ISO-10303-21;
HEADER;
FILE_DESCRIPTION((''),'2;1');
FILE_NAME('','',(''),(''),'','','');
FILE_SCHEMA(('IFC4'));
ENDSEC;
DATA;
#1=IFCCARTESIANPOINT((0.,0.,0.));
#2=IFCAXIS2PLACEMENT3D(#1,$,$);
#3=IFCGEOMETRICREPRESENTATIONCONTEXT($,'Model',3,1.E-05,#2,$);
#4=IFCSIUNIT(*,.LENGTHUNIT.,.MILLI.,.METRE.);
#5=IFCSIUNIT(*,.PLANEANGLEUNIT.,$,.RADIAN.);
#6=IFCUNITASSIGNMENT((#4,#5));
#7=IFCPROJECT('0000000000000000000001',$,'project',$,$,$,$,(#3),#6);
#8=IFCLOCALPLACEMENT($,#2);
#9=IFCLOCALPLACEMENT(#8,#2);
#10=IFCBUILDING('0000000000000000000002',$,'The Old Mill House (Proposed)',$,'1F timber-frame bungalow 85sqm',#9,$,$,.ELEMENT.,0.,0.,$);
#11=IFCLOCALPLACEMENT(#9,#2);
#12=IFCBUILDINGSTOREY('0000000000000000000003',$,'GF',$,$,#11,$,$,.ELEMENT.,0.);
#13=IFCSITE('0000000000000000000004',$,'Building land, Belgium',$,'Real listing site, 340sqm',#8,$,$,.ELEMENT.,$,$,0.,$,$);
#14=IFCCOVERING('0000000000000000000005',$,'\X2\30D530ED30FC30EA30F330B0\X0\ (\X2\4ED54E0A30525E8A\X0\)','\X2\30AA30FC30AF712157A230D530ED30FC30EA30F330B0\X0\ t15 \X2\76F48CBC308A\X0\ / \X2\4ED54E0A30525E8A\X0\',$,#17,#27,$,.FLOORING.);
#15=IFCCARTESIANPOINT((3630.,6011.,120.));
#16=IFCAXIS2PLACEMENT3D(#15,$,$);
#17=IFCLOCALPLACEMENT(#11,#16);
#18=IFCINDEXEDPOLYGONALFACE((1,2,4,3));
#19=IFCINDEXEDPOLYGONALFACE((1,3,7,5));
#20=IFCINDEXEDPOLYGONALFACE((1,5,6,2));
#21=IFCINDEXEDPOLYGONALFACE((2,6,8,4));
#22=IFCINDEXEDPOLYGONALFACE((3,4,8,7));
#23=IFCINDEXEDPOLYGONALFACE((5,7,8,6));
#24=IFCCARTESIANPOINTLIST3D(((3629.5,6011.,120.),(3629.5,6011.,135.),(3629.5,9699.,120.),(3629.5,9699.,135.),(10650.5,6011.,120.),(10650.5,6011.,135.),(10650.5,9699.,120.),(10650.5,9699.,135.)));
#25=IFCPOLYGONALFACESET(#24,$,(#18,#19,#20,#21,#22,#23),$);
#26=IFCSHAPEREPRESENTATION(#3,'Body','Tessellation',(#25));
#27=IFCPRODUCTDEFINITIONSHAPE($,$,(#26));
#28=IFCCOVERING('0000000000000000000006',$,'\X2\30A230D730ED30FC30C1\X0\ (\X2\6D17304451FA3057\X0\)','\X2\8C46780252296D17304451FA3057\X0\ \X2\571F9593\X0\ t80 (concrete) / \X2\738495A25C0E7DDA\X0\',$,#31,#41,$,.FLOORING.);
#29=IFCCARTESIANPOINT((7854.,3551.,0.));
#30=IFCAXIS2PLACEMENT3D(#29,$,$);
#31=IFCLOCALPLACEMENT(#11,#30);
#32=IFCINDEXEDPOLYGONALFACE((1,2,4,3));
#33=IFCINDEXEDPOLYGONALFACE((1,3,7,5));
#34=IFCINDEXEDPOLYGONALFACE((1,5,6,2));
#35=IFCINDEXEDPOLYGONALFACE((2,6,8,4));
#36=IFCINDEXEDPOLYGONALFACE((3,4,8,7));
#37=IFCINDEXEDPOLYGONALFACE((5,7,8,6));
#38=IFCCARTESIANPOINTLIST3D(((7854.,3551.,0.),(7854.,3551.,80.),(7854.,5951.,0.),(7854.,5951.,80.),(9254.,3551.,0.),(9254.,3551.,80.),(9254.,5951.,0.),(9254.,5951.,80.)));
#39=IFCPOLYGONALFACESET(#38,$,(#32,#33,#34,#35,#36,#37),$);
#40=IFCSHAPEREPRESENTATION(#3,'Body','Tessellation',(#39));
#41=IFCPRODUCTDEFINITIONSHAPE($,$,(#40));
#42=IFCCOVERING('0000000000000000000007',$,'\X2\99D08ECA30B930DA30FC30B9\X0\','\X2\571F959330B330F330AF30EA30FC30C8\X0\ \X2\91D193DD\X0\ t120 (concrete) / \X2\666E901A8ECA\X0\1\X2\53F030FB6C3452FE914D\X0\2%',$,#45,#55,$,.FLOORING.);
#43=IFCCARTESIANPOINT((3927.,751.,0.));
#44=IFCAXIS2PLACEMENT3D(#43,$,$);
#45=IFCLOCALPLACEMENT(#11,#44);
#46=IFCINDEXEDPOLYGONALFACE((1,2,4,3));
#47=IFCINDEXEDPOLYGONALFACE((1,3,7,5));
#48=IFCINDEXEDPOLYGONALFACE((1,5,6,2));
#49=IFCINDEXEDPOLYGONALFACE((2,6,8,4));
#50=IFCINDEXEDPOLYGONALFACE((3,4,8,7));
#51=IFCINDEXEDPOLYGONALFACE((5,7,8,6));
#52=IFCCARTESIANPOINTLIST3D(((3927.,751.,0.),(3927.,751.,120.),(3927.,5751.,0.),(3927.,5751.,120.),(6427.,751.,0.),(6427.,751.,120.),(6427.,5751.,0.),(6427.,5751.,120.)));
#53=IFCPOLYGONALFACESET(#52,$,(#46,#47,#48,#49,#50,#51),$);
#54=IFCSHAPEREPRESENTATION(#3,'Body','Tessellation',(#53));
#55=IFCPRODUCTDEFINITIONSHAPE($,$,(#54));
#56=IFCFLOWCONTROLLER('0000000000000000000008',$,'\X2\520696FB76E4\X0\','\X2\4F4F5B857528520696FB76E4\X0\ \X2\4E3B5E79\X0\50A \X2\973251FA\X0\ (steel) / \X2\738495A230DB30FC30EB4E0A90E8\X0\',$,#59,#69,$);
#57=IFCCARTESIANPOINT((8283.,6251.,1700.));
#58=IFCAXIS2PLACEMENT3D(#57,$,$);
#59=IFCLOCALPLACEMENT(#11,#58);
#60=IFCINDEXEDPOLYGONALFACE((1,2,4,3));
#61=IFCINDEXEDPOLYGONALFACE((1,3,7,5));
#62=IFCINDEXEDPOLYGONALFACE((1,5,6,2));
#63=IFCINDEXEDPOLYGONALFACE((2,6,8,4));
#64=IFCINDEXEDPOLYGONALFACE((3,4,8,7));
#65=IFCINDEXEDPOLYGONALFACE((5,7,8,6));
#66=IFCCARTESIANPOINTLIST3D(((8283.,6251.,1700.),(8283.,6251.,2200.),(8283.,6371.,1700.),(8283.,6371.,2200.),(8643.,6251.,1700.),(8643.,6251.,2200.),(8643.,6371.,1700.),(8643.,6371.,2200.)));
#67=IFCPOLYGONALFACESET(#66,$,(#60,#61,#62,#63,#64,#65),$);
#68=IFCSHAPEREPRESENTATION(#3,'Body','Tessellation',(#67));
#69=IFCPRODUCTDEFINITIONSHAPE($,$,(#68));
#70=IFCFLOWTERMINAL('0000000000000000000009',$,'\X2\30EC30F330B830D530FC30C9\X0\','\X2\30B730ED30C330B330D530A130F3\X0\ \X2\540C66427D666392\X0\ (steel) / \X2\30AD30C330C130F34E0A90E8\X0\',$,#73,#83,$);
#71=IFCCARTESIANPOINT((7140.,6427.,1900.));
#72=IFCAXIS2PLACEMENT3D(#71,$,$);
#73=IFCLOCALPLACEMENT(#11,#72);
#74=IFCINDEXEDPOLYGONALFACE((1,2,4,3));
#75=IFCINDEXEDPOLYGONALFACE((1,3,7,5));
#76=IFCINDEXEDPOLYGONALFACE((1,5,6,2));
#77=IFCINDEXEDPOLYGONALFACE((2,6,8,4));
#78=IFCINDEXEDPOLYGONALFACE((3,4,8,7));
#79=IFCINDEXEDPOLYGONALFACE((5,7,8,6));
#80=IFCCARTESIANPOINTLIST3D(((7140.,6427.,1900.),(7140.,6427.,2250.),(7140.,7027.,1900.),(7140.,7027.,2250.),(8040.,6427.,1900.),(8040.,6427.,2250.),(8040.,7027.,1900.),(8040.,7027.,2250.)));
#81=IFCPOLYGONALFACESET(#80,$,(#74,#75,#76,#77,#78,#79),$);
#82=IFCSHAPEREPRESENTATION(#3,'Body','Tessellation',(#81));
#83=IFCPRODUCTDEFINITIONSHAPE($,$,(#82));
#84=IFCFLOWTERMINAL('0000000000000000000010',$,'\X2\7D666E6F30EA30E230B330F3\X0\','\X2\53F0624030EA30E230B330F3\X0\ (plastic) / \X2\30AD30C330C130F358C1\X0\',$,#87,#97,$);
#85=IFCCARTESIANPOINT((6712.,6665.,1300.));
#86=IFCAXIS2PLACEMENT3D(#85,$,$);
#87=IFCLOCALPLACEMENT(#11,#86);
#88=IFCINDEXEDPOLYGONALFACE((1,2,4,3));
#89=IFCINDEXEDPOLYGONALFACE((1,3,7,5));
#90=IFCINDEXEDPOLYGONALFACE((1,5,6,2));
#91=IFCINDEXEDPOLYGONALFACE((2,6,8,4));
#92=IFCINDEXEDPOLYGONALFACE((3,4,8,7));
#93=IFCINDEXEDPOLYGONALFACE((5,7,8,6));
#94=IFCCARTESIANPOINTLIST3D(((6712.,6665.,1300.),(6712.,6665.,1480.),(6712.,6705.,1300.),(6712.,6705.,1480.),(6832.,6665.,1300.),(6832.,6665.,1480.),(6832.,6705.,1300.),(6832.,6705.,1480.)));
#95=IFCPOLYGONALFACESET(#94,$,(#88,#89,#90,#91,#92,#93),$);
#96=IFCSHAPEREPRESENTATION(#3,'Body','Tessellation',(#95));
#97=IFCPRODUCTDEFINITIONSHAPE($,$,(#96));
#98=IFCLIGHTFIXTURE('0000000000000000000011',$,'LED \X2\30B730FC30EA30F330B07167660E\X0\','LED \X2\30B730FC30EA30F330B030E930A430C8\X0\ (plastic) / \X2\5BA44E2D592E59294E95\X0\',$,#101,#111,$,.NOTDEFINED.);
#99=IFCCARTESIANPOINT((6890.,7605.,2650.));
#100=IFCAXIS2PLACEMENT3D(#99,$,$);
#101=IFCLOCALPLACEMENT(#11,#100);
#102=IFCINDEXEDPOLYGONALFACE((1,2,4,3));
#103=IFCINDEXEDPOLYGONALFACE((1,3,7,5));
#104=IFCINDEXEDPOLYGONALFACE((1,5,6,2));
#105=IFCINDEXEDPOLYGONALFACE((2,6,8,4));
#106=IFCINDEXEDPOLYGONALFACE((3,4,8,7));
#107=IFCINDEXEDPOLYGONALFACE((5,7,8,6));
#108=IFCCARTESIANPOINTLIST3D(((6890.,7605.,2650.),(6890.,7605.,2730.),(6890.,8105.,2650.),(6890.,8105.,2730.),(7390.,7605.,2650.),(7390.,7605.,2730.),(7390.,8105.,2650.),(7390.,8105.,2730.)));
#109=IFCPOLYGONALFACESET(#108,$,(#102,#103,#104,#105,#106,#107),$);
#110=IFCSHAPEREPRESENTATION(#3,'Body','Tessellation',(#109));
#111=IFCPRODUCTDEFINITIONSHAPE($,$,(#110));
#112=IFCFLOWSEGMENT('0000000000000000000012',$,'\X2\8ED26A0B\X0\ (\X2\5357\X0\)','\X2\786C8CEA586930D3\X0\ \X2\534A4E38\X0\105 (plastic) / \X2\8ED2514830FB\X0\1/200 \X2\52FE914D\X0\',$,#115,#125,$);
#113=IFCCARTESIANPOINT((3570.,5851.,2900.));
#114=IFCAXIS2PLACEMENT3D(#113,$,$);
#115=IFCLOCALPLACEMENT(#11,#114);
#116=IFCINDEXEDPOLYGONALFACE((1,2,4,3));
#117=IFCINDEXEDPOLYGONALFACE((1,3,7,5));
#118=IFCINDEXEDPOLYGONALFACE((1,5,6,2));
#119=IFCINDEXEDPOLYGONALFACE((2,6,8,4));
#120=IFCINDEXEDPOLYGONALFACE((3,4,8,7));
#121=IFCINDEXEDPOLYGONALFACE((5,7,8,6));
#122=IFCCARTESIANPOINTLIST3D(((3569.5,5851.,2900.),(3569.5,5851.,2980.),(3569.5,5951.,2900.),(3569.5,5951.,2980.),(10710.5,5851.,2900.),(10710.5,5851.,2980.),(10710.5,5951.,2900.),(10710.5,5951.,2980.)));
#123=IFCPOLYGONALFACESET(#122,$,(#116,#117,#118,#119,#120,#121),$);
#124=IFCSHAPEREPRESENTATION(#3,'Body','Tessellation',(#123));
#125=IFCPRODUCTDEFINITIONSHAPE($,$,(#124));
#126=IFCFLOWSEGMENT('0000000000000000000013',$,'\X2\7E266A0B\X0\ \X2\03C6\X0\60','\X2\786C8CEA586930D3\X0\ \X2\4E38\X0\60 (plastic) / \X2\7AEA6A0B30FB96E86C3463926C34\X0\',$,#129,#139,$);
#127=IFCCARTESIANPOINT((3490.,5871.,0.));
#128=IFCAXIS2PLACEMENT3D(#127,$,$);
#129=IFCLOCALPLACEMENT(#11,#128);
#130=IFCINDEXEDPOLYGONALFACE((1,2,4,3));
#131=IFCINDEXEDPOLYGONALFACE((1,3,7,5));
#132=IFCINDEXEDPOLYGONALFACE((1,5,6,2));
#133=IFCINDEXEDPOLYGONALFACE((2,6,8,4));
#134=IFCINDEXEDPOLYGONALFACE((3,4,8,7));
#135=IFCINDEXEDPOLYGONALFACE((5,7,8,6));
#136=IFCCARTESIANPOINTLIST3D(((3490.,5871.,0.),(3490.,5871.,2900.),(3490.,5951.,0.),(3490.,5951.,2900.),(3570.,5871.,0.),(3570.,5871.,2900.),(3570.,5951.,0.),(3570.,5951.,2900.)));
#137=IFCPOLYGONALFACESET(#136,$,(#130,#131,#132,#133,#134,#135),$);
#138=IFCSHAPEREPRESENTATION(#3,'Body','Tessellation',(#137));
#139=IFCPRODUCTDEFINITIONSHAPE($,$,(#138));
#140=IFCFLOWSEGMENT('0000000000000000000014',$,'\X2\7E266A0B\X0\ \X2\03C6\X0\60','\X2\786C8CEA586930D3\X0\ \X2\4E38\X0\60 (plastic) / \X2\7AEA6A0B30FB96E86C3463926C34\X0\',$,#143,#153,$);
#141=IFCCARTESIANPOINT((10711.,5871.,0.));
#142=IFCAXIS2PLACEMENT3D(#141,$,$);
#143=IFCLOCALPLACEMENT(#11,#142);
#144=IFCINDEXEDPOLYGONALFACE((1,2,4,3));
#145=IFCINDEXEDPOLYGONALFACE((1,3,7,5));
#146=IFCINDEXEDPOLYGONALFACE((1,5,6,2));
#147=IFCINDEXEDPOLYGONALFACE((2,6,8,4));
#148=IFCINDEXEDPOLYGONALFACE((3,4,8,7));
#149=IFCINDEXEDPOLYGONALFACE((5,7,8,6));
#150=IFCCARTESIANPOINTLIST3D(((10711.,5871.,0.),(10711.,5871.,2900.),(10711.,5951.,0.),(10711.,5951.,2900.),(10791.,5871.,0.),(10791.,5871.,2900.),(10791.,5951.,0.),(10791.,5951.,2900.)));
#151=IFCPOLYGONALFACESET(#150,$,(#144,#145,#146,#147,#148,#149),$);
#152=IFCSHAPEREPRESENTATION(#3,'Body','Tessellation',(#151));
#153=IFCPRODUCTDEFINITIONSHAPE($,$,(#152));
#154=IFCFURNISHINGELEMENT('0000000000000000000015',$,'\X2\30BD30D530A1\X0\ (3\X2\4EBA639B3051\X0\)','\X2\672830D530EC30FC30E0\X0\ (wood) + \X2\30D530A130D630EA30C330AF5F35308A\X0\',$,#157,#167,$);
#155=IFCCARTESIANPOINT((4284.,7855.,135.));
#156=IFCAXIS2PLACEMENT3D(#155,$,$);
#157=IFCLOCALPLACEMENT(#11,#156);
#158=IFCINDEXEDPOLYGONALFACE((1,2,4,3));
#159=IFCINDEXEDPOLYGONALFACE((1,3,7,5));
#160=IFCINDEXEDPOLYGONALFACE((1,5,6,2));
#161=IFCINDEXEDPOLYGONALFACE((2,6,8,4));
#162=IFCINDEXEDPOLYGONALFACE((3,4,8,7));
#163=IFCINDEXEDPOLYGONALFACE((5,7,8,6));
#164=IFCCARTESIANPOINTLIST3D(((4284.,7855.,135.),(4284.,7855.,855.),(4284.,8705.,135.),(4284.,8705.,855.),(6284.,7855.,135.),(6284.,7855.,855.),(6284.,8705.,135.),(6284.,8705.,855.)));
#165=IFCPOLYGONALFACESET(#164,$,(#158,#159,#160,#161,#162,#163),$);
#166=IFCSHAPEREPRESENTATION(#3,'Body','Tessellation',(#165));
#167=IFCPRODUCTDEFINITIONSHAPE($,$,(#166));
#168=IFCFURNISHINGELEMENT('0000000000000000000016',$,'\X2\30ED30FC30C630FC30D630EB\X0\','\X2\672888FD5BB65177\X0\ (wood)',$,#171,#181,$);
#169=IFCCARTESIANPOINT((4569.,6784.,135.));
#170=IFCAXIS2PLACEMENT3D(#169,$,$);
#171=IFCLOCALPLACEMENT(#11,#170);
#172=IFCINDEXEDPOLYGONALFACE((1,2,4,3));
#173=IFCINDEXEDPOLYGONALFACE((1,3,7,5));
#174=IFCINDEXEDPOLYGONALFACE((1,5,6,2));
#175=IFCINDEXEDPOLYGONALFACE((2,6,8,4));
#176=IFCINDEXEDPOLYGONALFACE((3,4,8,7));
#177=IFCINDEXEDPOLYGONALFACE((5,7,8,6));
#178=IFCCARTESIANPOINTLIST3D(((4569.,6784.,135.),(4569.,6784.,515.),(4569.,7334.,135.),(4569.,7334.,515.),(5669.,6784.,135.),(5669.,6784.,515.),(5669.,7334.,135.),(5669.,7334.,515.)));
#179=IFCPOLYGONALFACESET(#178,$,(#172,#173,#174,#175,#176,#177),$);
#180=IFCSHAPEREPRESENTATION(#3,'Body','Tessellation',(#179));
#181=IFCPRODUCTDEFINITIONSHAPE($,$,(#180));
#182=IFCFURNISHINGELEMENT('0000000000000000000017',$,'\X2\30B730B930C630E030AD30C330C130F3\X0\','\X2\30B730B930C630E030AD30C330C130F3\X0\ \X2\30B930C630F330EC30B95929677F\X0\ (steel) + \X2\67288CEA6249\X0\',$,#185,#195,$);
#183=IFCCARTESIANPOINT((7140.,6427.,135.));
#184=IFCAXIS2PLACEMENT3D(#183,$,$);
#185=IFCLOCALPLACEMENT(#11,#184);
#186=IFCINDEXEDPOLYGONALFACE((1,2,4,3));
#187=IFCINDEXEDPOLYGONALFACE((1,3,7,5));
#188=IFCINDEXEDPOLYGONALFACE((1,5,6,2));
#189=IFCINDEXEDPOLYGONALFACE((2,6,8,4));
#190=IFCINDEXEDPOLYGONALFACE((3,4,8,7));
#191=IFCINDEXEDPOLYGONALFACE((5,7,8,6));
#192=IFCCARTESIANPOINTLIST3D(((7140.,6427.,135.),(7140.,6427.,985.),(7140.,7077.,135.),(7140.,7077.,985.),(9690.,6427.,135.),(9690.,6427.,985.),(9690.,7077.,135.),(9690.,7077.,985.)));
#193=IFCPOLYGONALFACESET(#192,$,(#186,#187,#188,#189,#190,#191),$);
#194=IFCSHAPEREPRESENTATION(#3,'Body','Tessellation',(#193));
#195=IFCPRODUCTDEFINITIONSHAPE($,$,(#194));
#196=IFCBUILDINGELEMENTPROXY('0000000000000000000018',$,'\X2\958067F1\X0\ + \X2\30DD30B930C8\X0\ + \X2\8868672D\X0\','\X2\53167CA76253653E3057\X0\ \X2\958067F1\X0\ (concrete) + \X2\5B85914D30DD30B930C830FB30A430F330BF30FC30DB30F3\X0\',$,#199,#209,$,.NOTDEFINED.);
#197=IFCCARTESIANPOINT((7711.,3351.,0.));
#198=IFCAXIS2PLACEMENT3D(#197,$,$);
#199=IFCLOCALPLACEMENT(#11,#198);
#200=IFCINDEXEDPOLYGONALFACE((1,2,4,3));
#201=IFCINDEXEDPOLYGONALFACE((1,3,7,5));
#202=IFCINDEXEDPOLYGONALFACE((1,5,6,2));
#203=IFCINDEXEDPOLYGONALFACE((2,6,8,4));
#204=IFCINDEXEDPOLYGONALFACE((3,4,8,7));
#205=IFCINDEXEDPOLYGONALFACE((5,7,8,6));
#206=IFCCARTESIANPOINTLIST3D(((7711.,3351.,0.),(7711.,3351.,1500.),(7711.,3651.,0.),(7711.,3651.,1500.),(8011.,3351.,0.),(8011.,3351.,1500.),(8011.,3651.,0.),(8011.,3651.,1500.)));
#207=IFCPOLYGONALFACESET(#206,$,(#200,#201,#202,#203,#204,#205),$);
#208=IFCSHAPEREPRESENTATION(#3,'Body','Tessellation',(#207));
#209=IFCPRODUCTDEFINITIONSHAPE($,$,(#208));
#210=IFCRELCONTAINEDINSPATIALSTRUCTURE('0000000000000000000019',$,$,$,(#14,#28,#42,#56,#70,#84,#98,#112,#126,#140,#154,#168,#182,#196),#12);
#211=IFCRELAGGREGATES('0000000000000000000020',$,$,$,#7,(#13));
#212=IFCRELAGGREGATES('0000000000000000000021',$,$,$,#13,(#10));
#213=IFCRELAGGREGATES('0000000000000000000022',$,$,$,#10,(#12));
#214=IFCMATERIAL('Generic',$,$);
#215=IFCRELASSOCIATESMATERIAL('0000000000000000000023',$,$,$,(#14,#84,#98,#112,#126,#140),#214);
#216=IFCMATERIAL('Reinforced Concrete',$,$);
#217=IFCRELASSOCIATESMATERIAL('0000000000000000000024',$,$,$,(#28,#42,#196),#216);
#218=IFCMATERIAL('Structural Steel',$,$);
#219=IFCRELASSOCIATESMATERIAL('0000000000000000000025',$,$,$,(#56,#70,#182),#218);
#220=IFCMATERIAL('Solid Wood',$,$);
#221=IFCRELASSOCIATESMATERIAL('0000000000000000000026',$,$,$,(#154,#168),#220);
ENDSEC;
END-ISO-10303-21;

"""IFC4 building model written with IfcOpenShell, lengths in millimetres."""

from ifc_helpers import new_model, si_unit, frame, frame_2d, origin, place, context, project, spatial, rectangle, extrude, material, element, save


model = new_model("IFC4")

# Units and contexts
model_context = context("Model", 3, precision=1e-05, world=origin())
ifc_project = project(units=[si_unit("LENGTHUNIT", "METRE", prefix="MILLI"), si_unit("PLANEANGLEUNIT", "RADIAN")], contexts=[model_context])

# Site, building, storey
site_placement = place(None, origin())
site = spatial("IfcSite", under=ifc_project, at=site_placement, Name="Building land, Belgium", ObjectType="Real listing site, 340sqm", CompositionType="ELEMENT", RefElevation=0.0)
building_placement = place(site_placement, origin())
building = spatial("IfcBuilding", under=site, at=building_placement, Name="The Old Mill House (Proposed)", ObjectType="1F timber-frame bungalow 85sqm", CompositionType="ELEMENT", ElevationOfRefHeight=0.0, ElevationOfTerrain=0.0)
storey_placement = place(building_placement, origin())
storey = spatial("IfcBuildingStorey", under=building, at=storey_placement, Name="GF", CompositionType="ELEMENT", Elevation=0.0)

# Shared definitions
ifc_material_1 = material(Name="Solid Wood")

# Shared definitions
ifc_material_2 = material(Name="Reinforced Concrete")

# Shared definitions
ifc_material_3 = material(Name="Structural Steel")

# Coverings
ifc_material_4 = material(Name="Generic")
covering_1_placement = place(storey_placement, frame((3630.0, 6011.0, 120.0)))
element("IfcCovering", 1, at=covering_1_placement, inside=storey, material=ifc_material_4, Name="フローリング (仕上げ床)", Description="オーク無垢フローリング t15 直貼り / 仕上げ床", PredefinedType="FLOORING", context=model_context, shape_type="SweptSolid", body=[
    extrude(rectangle(XDim=7021.0, YDim=3688.0, at=frame_2d((3510.0, 1844.0))), frame((3630.0, 6011.0, 120.0)), (0.0, 0.0, 1.0), 15.0),
])
covering_2_placement = place(storey_placement, frame((7854.0, 3551.0, 0.0)))
element("IfcCovering", 2, at=covering_2_placement, inside=storey, material=ifc_material_2, Name="アプローチ (洗い出し)", Description="豆砂利洗い出し 土間 t80 (concrete) / 玄関導線", PredefinedType="FLOORING", context=model_context, shape_type="SweptSolid", body=[
    extrude(rectangle(XDim=1400.0, YDim=2400.0, at=frame_2d((700.0, 1200.0))), frame((7854.0, 3551.0, 0.0)), (0.0, 0.0, 1.0), 80.0),
])
covering_3_placement = place(storey_placement, frame((3927.0, 751.0, 0.0)))
element("IfcCovering", 3, at=covering_3_placement, inside=storey, material=ifc_material_2, Name="駐車スペース", Description="土間コンクリート 金鏝 t120 (concrete) / 普通車1台・水勾配2%", PredefinedType="FLOORING", context=model_context, shape_type="SweptSolid", body=[
    extrude(rectangle(XDim=2500.0, YDim=5000.0, at=frame_2d((1250.0, 2500.0))), frame((3927.0, 751.0, 0.0)), (0.0, 0.0, 1.0), 120.0),
])

# Flow controller
flow_controller_placement = place(storey_placement, frame((8283.0, 6251.0, 1700.0)))
element("IfcFlowController", 4, at=flow_controller_placement, inside=storey, material=ifc_material_3, Name="分電盤", Description="住宅用分電盤 主幹50A 露出 (steel) / 玄関ホール上部", context=model_context, shape_type="SweptSolid", body=[
    extrude(rectangle(XDim=360.0, YDim=120.0, at=frame_2d((180.0, 60.0))), frame((8283.0, 6251.0, 1700.0)), (0.0, 0.0, 1.0), 500.0),
])

# Flow terminals
flow_terminal_1_placement = place(storey_placement, frame((7140.0, 6427.0, 1900.0)))
element("IfcFlowTerminal", 5, at=flow_terminal_1_placement, inside=storey, material=ifc_material_3, Name="レンジフード", Description="シロッコファン 同時給排 (steel) / キッチン上部", context=model_context, shape_type="SweptSolid", body=[
    extrude(rectangle(XDim=900.0, YDim=600.0, at=frame_2d((450.0, 300.0))), frame((7140.0, 6427.0, 1900.0)), (0.0, 0.0, 1.0), 350.0),
])
flow_terminal_2_placement = place(storey_placement, frame((6712.0, 6665.0, 1300.0)))
element("IfcFlowTerminal", 6, at=flow_terminal_2_placement, inside=storey, material=ifc_material_4, Name="給湯リモコン", Description="台所リモコン (plastic) / キッチン壁", context=model_context, shape_type="SweptSolid", body=[
    extrude(rectangle(XDim=120.0, YDim=40.0, at=frame_2d((60.0, 20.0))), frame((6712.0, 6665.0, 1300.0)), (0.0, 0.0, 1.0), 180.0),
])

# Light fixture
light_fixture_placement = place(storey_placement, frame((6890.0, 7605.0, 2650.0)))
element("IfcLightFixture", 7, at=light_fixture_placement, inside=storey, material=ifc_material_4, Name="LED シーリング照明", Description="LED シーリングライト (plastic) / 室中央天井", PredefinedType="NOTDEFINED", context=model_context, shape_type="SweptSolid", body=[
    extrude(rectangle(XDim=500.0, YDim=500.0, at=frame_2d((250.0, 250.0))), frame((6890.0, 7605.0, 2650.0)), (0.0, 0.0, 1.0), 80.0),
])

# Flow segments
flow_segment_1_placement = place(storey_placement, frame((3570.0, 5851.0, 2900.0)))
element("IfcFlowSegment", 8, at=flow_segment_1_placement, inside=storey, material=ifc_material_4, Name="軒樋 (南)", Description="硬質塩ビ 半丸105 (plastic) / 軒先・1/200 勾配", context=model_context, shape_type="SweptSolid", body=[
    extrude(rectangle(XDim=7141.0, YDim=100.0, at=frame_2d((3570.0, 50.0))), frame((3570.0, 5851.0, 2900.0)), (0.0, 0.0, 1.0), 80.0),
])
flow_segment_2_placement = place(storey_placement, frame((3490.0, 5871.0, 0.0)))
element("IfcFlowSegment", 9, at=flow_segment_2_placement, inside=storey, material=ifc_material_4, Name="縦樋 φ60", Description="硬質塩ビ 丸60 (plastic) / 竪樋・雨水排水", context=model_context, shape_type="SweptSolid", body=[
    extrude(rectangle(XDim=80.0, YDim=80.0, at=frame_2d((40.0, 40.0))), frame((3490.0, 5871.0, 0.0)), (0.0, 0.0, 1.0), 2900.0),
])
flow_segment_3_placement = place(storey_placement, frame((10711.0, 5871.0, 0.0)))
element("IfcFlowSegment", 10, at=flow_segment_3_placement, inside=storey, material=ifc_material_4, Name="縦樋 φ60", Description="硬質塩ビ 丸60 (plastic) / 竪樋・雨水排水", context=model_context, shape_type="SweptSolid", body=[
    extrude(rectangle(XDim=80.0, YDim=80.0, at=frame_2d((40.0, 40.0))), frame((10711.0, 5871.0, 0.0)), (0.0, 0.0, 1.0), 2900.0),
])

# Furnishing elements
furnishing_1_placement = place(storey_placement, frame((4284.0, 7855.0, 135.0)))
element("IfcFurnishingElement", 11, at=furnishing_1_placement, inside=storey, material=ifc_material_1, Name="ソファ (3人掛け)", Description="木フレーム (wood) + ファブリック張り", context=model_context, shape_type="SweptSolid", body=[
    extrude(rectangle(XDim=2000.0, YDim=850.0, at=frame_2d((1000.0, 425.0))), frame((4284.0, 7855.0, 135.0)), (0.0, 0.0, 1.0), 720.0),
])
furnishing_2_placement = place(storey_placement, frame((4569.0, 6784.0, 135.0)))
element("IfcFurnishingElement", 12, at=furnishing_2_placement, inside=storey, material=ifc_material_1, Name="ローテーブル", Description="木製家具 (wood)", context=model_context, shape_type="SweptSolid", body=[
    extrude(rectangle(XDim=1100.0, YDim=550.0, at=frame_2d((550.0, 275.0))), frame((4569.0, 6784.0, 135.0)), (0.0, 0.0, 1.0), 380.0),
])
furnishing_3_placement = place(storey_placement, frame((7140.0, 6427.0, 135.0)))
element("IfcFurnishingElement", 13, at=furnishing_3_placement, inside=storey, material=ifc_material_3, Name="システムキッチン", Description="システムキッチン ステンレス天板 (steel) + 木質扉", context=model_context, shape_type="SweptSolid", body=[
    extrude(rectangle(XDim=2550.0, YDim=650.0, at=frame_2d((1275.0, 325.0))), frame((7140.0, 6427.0, 135.0)), (0.0, 0.0, 1.0), 850.0),
])

# Building element proxy
proxy_placement = place(storey_placement, frame((7711.0, 3351.0, 0.0)))
element("IfcBuildingElementProxy", 14, at=proxy_placement, inside=storey, material=ifc_material_2, Name="門柱 + ポスト + 表札", Description="化粧打放し 門柱 (concrete) + 宅配ポスト・インターホン", PredefinedType="NOTDEFINED", context=model_context, shape_type="SweptSolid", body=[
    extrude(rectangle(XDim=300.0, YDim=300.0, at=frame_2d((150.0, 150.0))), frame((7711.0, 3351.0, 0.0)), (0.0, 0.0, 1.0), 1500.0),
])

save(model, "model.ifc")
